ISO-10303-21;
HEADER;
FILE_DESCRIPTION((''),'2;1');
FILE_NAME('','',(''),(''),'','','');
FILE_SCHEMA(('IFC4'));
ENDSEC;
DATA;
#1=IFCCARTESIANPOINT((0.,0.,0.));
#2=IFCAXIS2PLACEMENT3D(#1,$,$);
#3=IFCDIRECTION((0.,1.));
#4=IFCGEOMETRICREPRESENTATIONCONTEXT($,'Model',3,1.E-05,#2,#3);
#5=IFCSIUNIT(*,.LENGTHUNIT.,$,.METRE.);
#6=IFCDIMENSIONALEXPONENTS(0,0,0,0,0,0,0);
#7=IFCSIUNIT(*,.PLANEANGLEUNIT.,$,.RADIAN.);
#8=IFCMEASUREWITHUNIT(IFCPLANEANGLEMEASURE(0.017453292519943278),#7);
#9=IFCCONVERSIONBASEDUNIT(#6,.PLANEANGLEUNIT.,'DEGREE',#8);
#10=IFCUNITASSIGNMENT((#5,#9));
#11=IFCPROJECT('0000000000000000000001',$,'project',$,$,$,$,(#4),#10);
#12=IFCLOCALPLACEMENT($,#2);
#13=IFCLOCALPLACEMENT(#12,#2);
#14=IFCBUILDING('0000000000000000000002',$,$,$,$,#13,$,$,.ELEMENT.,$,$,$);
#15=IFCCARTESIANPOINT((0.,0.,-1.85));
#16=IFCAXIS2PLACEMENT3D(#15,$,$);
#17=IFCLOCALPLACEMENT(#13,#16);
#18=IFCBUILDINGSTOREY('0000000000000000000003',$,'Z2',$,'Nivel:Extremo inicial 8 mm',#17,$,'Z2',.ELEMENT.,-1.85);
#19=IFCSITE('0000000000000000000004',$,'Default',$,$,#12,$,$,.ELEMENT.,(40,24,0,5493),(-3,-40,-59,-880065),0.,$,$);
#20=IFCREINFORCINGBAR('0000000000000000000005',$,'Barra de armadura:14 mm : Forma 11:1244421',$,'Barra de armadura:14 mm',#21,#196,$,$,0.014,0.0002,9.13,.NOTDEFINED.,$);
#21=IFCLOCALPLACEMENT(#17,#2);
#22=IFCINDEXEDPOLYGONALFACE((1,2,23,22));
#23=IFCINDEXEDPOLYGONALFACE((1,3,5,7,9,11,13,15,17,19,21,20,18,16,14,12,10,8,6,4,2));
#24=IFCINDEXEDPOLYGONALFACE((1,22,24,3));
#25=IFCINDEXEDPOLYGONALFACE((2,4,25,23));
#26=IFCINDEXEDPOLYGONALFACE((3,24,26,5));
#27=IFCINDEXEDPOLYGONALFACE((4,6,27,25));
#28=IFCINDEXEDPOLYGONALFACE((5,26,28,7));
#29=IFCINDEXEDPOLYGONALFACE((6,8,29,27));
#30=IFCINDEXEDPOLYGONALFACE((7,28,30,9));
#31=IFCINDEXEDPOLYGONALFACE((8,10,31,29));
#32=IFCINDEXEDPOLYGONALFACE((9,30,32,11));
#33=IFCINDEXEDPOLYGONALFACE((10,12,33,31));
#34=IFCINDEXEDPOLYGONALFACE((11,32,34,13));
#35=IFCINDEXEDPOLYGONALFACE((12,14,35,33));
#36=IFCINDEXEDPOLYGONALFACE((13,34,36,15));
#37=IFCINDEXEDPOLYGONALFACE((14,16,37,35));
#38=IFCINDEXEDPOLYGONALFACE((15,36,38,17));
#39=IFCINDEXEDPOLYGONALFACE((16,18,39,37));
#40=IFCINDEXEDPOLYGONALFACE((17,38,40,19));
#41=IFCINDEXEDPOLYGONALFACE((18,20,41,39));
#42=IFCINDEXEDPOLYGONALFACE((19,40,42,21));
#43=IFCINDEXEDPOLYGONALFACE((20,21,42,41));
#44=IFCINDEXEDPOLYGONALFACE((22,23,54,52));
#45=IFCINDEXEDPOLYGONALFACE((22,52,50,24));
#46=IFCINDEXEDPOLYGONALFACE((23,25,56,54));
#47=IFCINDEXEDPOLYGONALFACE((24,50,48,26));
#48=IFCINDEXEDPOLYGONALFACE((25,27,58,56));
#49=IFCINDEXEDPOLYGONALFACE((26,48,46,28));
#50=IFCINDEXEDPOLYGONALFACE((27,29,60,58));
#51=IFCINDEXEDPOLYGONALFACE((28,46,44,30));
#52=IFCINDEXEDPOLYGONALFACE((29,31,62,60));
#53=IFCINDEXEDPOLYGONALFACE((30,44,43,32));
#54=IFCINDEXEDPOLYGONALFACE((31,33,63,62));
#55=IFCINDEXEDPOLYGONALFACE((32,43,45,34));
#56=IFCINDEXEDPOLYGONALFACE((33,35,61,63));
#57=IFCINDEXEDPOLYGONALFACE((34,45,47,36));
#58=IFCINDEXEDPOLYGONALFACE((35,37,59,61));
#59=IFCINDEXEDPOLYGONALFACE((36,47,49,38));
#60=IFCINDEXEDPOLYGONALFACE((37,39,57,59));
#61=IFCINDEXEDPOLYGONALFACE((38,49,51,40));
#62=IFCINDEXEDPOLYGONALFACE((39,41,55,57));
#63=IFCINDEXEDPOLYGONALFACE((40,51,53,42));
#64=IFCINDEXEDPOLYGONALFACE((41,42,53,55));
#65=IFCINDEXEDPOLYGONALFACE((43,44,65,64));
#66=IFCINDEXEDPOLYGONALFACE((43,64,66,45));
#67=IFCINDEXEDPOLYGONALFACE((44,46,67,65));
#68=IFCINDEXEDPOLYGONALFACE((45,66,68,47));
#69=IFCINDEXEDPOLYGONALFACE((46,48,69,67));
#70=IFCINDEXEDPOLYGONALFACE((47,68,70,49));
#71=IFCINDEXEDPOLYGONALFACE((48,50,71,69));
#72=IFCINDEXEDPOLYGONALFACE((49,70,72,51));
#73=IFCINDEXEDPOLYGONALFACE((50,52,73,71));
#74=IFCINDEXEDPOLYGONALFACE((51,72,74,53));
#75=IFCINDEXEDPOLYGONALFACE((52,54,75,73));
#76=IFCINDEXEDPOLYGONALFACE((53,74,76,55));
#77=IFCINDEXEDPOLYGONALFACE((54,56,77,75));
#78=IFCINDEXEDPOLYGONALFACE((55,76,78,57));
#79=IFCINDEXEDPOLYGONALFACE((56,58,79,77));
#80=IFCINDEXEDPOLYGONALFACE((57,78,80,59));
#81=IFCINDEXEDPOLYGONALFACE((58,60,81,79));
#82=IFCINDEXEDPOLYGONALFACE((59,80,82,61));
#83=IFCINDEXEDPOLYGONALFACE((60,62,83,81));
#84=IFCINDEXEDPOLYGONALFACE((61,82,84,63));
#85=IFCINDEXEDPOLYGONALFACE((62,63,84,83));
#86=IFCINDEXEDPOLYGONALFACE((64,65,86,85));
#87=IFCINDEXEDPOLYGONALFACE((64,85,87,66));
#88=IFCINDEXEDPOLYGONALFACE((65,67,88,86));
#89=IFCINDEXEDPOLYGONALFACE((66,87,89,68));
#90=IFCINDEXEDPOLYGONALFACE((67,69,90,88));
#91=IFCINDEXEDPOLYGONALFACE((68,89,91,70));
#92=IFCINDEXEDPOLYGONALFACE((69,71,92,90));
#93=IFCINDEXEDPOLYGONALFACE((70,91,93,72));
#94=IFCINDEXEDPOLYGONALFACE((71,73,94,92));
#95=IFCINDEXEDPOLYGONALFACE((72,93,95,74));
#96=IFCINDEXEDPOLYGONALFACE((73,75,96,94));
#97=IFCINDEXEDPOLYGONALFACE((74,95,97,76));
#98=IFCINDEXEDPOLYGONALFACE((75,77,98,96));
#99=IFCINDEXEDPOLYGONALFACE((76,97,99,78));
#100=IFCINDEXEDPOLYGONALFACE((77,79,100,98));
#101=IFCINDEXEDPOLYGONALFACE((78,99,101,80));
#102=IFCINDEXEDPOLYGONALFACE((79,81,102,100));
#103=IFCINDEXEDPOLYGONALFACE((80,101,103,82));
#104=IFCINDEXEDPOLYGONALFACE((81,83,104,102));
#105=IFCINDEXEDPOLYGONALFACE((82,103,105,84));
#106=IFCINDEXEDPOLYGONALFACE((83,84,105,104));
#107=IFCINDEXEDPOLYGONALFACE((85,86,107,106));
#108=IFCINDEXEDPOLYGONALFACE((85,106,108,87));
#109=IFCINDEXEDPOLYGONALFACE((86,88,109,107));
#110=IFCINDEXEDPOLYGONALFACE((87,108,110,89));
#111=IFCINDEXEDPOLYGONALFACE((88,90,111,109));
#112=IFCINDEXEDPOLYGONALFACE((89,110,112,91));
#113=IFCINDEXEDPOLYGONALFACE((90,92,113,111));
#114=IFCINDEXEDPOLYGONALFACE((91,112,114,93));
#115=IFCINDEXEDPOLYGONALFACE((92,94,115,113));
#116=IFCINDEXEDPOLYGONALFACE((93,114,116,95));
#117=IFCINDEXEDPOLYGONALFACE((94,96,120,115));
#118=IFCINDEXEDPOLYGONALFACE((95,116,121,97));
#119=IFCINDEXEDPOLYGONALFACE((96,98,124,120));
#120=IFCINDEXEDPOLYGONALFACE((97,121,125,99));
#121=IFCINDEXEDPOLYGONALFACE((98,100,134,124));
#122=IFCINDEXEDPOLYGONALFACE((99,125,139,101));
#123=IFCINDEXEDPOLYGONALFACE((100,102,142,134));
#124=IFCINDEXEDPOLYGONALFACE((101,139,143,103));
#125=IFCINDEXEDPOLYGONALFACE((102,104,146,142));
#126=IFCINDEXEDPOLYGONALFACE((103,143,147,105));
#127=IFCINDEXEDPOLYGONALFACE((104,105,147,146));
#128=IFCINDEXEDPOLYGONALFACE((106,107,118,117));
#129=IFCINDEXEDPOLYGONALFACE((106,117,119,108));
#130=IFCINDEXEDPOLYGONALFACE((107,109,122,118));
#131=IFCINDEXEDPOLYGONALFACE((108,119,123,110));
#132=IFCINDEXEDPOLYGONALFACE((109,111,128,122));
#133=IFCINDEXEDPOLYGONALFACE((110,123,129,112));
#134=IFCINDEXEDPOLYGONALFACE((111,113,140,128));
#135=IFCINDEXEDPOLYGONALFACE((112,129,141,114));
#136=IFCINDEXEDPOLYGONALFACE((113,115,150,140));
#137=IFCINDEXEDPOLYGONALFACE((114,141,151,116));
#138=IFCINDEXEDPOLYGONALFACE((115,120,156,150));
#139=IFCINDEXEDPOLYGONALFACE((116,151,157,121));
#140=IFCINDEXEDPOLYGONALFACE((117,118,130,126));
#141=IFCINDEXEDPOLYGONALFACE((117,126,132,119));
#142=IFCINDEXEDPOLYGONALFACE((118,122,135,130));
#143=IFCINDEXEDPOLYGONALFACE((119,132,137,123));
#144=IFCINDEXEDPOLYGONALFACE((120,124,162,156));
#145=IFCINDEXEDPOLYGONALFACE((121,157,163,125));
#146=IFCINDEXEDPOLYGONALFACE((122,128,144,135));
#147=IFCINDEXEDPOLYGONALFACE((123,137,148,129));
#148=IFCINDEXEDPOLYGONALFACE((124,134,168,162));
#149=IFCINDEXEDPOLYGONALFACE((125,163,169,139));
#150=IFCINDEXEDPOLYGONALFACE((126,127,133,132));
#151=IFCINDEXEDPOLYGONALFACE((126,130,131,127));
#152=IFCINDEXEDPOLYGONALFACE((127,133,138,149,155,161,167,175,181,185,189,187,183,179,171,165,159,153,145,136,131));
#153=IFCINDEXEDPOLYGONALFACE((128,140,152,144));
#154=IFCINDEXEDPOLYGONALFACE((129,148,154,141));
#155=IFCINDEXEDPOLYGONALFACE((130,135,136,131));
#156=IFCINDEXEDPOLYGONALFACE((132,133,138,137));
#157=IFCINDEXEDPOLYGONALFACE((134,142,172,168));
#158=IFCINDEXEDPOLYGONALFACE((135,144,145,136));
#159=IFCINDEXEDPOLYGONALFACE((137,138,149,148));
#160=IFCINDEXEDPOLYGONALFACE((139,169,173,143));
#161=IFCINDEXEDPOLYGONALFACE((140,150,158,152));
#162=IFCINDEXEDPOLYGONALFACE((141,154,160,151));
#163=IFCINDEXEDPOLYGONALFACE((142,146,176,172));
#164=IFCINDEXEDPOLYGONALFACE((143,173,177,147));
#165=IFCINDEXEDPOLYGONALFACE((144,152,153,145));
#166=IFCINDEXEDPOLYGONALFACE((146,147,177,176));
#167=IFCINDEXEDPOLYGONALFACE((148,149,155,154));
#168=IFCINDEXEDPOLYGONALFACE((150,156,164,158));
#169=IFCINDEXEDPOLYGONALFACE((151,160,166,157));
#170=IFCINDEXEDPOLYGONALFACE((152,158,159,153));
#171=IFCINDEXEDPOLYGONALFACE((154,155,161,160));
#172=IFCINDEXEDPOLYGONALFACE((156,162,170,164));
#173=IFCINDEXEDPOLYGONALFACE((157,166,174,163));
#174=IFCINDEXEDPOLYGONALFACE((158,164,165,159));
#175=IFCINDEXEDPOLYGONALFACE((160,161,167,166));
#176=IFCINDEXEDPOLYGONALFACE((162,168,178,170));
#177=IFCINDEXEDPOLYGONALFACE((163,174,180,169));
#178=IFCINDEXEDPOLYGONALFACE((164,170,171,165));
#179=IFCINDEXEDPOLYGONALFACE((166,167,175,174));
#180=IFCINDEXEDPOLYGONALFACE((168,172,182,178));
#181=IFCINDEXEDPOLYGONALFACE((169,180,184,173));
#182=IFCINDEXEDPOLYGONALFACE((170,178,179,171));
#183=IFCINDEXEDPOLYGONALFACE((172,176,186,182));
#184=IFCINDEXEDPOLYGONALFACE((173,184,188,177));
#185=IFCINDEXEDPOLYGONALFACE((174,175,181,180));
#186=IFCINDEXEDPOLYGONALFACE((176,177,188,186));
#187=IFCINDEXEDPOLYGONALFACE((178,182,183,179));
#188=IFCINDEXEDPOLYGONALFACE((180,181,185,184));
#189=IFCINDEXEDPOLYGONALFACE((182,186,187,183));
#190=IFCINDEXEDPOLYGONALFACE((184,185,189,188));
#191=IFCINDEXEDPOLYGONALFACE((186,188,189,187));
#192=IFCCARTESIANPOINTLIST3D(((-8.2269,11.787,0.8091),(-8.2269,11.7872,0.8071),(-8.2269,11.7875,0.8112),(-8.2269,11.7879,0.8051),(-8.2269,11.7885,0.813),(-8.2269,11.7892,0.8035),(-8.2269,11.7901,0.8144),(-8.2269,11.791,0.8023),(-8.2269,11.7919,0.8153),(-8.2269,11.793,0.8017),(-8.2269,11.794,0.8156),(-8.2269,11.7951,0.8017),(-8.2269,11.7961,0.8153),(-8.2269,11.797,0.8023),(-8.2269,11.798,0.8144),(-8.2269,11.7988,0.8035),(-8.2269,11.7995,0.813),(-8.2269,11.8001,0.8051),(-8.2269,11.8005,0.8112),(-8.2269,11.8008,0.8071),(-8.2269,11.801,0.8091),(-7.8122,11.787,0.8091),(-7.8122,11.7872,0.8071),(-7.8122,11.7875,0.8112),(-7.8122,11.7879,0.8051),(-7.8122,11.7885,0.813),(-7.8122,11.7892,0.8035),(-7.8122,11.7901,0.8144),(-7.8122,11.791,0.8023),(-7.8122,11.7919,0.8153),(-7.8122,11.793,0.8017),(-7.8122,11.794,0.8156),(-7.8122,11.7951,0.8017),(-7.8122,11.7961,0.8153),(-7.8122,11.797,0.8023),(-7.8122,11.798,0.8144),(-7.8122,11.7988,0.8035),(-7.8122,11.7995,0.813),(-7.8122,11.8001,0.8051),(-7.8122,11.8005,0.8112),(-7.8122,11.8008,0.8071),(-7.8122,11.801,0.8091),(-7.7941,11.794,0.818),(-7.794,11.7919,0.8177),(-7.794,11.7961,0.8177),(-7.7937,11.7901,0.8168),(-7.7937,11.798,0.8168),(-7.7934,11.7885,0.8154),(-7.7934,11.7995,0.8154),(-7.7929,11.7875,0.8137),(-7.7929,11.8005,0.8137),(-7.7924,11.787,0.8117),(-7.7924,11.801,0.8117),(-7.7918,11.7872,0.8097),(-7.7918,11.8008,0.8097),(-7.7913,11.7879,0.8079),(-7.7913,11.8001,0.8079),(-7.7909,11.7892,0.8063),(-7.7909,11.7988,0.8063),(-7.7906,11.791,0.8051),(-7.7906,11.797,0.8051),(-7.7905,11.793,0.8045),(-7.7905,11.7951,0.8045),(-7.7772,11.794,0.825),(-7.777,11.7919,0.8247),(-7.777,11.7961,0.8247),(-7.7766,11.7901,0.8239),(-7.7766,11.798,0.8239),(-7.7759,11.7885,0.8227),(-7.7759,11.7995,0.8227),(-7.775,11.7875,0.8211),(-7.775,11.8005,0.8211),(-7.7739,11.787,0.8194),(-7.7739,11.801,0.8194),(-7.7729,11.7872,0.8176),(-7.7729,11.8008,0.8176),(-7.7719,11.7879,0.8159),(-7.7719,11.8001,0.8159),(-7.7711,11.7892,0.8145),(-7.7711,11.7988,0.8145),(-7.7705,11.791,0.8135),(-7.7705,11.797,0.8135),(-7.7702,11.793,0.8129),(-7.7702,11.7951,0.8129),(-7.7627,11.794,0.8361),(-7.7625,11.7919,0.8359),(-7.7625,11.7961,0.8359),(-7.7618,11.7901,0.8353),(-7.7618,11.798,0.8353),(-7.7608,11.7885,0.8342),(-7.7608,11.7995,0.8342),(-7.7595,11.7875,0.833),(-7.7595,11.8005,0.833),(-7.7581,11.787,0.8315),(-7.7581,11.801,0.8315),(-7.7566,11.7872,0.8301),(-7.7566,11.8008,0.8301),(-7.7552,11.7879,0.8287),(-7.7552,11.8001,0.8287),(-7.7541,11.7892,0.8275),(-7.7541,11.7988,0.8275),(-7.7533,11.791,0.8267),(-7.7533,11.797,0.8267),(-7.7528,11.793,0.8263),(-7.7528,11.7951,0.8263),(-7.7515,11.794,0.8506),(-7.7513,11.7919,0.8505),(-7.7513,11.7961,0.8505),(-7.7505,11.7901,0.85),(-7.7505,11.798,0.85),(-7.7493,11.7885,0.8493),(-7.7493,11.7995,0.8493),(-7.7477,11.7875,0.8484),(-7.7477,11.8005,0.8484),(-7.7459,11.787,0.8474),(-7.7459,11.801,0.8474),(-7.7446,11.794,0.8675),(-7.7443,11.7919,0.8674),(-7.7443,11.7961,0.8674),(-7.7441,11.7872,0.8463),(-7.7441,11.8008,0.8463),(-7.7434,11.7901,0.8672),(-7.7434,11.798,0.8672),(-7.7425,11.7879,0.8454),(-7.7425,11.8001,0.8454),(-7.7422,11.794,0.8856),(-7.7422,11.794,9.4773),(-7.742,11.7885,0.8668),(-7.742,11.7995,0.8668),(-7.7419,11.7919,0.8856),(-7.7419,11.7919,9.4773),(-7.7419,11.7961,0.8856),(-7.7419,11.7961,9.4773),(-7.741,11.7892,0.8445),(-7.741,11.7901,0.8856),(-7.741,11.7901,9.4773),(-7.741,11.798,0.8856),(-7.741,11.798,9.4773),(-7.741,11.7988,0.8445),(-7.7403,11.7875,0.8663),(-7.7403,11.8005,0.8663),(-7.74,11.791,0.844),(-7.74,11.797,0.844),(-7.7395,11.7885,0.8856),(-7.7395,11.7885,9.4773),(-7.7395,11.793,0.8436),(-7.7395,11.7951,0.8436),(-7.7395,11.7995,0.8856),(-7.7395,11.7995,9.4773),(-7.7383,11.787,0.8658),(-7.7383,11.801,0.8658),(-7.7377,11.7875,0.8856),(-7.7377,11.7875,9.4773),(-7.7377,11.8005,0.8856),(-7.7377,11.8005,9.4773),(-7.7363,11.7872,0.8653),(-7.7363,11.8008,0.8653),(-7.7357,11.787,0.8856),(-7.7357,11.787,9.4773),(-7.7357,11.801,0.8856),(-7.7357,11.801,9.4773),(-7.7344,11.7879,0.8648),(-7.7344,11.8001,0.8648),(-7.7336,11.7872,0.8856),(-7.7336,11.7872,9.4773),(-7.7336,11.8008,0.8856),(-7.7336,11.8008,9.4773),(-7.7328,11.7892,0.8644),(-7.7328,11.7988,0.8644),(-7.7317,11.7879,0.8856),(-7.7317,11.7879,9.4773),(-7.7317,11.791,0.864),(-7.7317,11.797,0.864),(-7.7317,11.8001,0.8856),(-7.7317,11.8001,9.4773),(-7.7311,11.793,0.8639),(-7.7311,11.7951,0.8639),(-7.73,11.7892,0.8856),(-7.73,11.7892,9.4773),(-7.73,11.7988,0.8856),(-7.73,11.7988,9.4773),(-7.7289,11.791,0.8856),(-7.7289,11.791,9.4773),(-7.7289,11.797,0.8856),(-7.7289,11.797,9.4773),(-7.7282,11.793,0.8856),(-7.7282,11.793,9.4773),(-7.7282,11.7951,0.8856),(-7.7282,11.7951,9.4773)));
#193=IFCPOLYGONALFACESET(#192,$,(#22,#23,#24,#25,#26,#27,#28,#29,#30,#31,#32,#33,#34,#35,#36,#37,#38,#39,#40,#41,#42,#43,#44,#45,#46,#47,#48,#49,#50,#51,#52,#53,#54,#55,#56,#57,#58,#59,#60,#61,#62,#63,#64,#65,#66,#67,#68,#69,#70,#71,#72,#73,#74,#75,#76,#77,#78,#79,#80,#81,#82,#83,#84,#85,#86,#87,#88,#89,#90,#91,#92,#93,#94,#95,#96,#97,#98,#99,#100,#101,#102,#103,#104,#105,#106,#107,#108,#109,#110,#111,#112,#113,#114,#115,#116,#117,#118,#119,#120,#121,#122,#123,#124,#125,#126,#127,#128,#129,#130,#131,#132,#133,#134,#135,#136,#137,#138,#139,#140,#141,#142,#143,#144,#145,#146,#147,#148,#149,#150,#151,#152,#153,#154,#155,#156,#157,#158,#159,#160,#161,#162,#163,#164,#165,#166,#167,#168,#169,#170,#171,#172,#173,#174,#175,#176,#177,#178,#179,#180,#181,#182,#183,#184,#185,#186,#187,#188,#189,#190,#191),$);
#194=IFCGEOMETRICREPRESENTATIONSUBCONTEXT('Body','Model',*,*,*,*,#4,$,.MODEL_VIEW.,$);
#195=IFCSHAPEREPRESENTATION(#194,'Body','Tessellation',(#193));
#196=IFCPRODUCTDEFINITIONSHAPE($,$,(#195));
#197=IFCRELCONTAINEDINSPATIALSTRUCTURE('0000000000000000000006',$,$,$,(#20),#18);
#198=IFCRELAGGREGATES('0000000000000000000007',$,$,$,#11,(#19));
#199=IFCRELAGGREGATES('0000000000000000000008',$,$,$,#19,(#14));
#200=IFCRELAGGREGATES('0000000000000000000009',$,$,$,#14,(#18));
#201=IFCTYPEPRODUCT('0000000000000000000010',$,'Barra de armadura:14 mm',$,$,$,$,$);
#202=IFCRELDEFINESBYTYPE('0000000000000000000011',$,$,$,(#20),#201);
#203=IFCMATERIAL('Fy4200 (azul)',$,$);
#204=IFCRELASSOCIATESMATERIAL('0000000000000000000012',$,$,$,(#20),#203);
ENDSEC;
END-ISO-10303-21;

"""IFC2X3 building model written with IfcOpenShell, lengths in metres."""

from ifc_helpers import new_model, entity, si_unit, converted_unit, direction, frame, origin, place, context, subcontext, project, spatial, material, type_object, element, save


model = new_model("IFC2X3")

# Units and contexts
model_context = context("Model", 3, precision=1e-05, world=origin(), true_north=direction((0.0, 1.0)))
body_context = subcontext(model_context, "Body", "Model", "MODEL_VIEW")
ifc_project = project(units=[si_unit("LENGTHUNIT", "METRE"), converted_unit("PLANEANGLEUNIT", "DEGREE", entity("IfcPlaneAngleMeasure", 0.017453292519943278), si_unit("PLANEANGLEUNIT", "RADIAN"), dimensions=[0, 0, 0, 0, 0, 0, 0])], contexts=[model_context])

# Site, building, storey
site_placement = place(None, origin())
site = spatial("IfcSite", under=ifc_project, at=site_placement, Name="Default", CompositionType="ELEMENT", RefLatitude=(40, 24, 0, 5493), RefLongitude=(-3, -40, -59, -880065), RefElevation=0.0)
building_placement = place(site_placement, origin())
building = spatial("IfcBuilding", under=site, at=building_placement, CompositionType="ELEMENT")
storey_placement = place(building_placement, frame((0.0, 0.0, -1.85)))
storey = spatial("IfcBuildingStorey", under=building, at=storey_placement, Name="Z2", ObjectType="Nivel:Extremo inicial 8 mm", LongName="Z2", CompositionType="ELEMENT", Elevation=-1.85)

# Reinforcing bar
ifc_material_1 = material(Name="Fy4200 (azul)")
type_product_1 = type_object("IfcTypeProduct", Name="Barra de armadura:14 mm")
reinforcing_bar_1_placement = place(storey_placement, origin())
element("IfcReinforcingBar", 1, at=reinforcing_bar_1_placement, inside=storey, type_object=type_product_1, material=ifc_material_1, Name="Barra de armadura:14 mm : Forma 11:1244421", ObjectType="Barra de armadura:14 mm", BarLength=9.13, BarRole="NOTDEFINED", CrossSectionArea=0.0002, NominalDiameter=0.014, context=body_context, shape_type="AdvancedSweptSolid", body=[
    entity("IfcSweptDiskSolid", entity("IfcCompositeCurve", [entity("IfcCompositeCurveSegment", "CONTINUOUS", True, entity("IfcPolyline", [entity("IfcCartesianPoint", [-7.7352, 11.794, 9.4773]), entity("IfcCartesianPoint", [-7.7352, 11.794, 0.8856])])), entity("IfcCompositeCurveSegment", "CONTINUOUS", True, entity("IfcTrimmedCurve", entity("IfcCircle", entity("IfcAxis2Placement3D", entity("IfcCartesianPoint", [-7.8122, 11.794, 0.8856]), entity("IfcDirection", [0.0, 1.0, 0.0]), entity("IfcDirection", [0.0, 0.0, -1.0])), 0.077), [entity("IfcParameterValue", 270.0)], [entity("IfcParameterValue", 360.0)], True, "PARAMETER")), entity("IfcCompositeCurveSegment", "CONTINUOUS", True, entity("IfcPolyline", [entity("IfcCartesianPoint", [-7.8122, 11.794, 0.8086]), entity("IfcCartesianPoint", [-8.2269, 11.794, 0.8086])]))], False), 0.007, None, 0.0, 92.0),
])

save(model, "model.ifc")
